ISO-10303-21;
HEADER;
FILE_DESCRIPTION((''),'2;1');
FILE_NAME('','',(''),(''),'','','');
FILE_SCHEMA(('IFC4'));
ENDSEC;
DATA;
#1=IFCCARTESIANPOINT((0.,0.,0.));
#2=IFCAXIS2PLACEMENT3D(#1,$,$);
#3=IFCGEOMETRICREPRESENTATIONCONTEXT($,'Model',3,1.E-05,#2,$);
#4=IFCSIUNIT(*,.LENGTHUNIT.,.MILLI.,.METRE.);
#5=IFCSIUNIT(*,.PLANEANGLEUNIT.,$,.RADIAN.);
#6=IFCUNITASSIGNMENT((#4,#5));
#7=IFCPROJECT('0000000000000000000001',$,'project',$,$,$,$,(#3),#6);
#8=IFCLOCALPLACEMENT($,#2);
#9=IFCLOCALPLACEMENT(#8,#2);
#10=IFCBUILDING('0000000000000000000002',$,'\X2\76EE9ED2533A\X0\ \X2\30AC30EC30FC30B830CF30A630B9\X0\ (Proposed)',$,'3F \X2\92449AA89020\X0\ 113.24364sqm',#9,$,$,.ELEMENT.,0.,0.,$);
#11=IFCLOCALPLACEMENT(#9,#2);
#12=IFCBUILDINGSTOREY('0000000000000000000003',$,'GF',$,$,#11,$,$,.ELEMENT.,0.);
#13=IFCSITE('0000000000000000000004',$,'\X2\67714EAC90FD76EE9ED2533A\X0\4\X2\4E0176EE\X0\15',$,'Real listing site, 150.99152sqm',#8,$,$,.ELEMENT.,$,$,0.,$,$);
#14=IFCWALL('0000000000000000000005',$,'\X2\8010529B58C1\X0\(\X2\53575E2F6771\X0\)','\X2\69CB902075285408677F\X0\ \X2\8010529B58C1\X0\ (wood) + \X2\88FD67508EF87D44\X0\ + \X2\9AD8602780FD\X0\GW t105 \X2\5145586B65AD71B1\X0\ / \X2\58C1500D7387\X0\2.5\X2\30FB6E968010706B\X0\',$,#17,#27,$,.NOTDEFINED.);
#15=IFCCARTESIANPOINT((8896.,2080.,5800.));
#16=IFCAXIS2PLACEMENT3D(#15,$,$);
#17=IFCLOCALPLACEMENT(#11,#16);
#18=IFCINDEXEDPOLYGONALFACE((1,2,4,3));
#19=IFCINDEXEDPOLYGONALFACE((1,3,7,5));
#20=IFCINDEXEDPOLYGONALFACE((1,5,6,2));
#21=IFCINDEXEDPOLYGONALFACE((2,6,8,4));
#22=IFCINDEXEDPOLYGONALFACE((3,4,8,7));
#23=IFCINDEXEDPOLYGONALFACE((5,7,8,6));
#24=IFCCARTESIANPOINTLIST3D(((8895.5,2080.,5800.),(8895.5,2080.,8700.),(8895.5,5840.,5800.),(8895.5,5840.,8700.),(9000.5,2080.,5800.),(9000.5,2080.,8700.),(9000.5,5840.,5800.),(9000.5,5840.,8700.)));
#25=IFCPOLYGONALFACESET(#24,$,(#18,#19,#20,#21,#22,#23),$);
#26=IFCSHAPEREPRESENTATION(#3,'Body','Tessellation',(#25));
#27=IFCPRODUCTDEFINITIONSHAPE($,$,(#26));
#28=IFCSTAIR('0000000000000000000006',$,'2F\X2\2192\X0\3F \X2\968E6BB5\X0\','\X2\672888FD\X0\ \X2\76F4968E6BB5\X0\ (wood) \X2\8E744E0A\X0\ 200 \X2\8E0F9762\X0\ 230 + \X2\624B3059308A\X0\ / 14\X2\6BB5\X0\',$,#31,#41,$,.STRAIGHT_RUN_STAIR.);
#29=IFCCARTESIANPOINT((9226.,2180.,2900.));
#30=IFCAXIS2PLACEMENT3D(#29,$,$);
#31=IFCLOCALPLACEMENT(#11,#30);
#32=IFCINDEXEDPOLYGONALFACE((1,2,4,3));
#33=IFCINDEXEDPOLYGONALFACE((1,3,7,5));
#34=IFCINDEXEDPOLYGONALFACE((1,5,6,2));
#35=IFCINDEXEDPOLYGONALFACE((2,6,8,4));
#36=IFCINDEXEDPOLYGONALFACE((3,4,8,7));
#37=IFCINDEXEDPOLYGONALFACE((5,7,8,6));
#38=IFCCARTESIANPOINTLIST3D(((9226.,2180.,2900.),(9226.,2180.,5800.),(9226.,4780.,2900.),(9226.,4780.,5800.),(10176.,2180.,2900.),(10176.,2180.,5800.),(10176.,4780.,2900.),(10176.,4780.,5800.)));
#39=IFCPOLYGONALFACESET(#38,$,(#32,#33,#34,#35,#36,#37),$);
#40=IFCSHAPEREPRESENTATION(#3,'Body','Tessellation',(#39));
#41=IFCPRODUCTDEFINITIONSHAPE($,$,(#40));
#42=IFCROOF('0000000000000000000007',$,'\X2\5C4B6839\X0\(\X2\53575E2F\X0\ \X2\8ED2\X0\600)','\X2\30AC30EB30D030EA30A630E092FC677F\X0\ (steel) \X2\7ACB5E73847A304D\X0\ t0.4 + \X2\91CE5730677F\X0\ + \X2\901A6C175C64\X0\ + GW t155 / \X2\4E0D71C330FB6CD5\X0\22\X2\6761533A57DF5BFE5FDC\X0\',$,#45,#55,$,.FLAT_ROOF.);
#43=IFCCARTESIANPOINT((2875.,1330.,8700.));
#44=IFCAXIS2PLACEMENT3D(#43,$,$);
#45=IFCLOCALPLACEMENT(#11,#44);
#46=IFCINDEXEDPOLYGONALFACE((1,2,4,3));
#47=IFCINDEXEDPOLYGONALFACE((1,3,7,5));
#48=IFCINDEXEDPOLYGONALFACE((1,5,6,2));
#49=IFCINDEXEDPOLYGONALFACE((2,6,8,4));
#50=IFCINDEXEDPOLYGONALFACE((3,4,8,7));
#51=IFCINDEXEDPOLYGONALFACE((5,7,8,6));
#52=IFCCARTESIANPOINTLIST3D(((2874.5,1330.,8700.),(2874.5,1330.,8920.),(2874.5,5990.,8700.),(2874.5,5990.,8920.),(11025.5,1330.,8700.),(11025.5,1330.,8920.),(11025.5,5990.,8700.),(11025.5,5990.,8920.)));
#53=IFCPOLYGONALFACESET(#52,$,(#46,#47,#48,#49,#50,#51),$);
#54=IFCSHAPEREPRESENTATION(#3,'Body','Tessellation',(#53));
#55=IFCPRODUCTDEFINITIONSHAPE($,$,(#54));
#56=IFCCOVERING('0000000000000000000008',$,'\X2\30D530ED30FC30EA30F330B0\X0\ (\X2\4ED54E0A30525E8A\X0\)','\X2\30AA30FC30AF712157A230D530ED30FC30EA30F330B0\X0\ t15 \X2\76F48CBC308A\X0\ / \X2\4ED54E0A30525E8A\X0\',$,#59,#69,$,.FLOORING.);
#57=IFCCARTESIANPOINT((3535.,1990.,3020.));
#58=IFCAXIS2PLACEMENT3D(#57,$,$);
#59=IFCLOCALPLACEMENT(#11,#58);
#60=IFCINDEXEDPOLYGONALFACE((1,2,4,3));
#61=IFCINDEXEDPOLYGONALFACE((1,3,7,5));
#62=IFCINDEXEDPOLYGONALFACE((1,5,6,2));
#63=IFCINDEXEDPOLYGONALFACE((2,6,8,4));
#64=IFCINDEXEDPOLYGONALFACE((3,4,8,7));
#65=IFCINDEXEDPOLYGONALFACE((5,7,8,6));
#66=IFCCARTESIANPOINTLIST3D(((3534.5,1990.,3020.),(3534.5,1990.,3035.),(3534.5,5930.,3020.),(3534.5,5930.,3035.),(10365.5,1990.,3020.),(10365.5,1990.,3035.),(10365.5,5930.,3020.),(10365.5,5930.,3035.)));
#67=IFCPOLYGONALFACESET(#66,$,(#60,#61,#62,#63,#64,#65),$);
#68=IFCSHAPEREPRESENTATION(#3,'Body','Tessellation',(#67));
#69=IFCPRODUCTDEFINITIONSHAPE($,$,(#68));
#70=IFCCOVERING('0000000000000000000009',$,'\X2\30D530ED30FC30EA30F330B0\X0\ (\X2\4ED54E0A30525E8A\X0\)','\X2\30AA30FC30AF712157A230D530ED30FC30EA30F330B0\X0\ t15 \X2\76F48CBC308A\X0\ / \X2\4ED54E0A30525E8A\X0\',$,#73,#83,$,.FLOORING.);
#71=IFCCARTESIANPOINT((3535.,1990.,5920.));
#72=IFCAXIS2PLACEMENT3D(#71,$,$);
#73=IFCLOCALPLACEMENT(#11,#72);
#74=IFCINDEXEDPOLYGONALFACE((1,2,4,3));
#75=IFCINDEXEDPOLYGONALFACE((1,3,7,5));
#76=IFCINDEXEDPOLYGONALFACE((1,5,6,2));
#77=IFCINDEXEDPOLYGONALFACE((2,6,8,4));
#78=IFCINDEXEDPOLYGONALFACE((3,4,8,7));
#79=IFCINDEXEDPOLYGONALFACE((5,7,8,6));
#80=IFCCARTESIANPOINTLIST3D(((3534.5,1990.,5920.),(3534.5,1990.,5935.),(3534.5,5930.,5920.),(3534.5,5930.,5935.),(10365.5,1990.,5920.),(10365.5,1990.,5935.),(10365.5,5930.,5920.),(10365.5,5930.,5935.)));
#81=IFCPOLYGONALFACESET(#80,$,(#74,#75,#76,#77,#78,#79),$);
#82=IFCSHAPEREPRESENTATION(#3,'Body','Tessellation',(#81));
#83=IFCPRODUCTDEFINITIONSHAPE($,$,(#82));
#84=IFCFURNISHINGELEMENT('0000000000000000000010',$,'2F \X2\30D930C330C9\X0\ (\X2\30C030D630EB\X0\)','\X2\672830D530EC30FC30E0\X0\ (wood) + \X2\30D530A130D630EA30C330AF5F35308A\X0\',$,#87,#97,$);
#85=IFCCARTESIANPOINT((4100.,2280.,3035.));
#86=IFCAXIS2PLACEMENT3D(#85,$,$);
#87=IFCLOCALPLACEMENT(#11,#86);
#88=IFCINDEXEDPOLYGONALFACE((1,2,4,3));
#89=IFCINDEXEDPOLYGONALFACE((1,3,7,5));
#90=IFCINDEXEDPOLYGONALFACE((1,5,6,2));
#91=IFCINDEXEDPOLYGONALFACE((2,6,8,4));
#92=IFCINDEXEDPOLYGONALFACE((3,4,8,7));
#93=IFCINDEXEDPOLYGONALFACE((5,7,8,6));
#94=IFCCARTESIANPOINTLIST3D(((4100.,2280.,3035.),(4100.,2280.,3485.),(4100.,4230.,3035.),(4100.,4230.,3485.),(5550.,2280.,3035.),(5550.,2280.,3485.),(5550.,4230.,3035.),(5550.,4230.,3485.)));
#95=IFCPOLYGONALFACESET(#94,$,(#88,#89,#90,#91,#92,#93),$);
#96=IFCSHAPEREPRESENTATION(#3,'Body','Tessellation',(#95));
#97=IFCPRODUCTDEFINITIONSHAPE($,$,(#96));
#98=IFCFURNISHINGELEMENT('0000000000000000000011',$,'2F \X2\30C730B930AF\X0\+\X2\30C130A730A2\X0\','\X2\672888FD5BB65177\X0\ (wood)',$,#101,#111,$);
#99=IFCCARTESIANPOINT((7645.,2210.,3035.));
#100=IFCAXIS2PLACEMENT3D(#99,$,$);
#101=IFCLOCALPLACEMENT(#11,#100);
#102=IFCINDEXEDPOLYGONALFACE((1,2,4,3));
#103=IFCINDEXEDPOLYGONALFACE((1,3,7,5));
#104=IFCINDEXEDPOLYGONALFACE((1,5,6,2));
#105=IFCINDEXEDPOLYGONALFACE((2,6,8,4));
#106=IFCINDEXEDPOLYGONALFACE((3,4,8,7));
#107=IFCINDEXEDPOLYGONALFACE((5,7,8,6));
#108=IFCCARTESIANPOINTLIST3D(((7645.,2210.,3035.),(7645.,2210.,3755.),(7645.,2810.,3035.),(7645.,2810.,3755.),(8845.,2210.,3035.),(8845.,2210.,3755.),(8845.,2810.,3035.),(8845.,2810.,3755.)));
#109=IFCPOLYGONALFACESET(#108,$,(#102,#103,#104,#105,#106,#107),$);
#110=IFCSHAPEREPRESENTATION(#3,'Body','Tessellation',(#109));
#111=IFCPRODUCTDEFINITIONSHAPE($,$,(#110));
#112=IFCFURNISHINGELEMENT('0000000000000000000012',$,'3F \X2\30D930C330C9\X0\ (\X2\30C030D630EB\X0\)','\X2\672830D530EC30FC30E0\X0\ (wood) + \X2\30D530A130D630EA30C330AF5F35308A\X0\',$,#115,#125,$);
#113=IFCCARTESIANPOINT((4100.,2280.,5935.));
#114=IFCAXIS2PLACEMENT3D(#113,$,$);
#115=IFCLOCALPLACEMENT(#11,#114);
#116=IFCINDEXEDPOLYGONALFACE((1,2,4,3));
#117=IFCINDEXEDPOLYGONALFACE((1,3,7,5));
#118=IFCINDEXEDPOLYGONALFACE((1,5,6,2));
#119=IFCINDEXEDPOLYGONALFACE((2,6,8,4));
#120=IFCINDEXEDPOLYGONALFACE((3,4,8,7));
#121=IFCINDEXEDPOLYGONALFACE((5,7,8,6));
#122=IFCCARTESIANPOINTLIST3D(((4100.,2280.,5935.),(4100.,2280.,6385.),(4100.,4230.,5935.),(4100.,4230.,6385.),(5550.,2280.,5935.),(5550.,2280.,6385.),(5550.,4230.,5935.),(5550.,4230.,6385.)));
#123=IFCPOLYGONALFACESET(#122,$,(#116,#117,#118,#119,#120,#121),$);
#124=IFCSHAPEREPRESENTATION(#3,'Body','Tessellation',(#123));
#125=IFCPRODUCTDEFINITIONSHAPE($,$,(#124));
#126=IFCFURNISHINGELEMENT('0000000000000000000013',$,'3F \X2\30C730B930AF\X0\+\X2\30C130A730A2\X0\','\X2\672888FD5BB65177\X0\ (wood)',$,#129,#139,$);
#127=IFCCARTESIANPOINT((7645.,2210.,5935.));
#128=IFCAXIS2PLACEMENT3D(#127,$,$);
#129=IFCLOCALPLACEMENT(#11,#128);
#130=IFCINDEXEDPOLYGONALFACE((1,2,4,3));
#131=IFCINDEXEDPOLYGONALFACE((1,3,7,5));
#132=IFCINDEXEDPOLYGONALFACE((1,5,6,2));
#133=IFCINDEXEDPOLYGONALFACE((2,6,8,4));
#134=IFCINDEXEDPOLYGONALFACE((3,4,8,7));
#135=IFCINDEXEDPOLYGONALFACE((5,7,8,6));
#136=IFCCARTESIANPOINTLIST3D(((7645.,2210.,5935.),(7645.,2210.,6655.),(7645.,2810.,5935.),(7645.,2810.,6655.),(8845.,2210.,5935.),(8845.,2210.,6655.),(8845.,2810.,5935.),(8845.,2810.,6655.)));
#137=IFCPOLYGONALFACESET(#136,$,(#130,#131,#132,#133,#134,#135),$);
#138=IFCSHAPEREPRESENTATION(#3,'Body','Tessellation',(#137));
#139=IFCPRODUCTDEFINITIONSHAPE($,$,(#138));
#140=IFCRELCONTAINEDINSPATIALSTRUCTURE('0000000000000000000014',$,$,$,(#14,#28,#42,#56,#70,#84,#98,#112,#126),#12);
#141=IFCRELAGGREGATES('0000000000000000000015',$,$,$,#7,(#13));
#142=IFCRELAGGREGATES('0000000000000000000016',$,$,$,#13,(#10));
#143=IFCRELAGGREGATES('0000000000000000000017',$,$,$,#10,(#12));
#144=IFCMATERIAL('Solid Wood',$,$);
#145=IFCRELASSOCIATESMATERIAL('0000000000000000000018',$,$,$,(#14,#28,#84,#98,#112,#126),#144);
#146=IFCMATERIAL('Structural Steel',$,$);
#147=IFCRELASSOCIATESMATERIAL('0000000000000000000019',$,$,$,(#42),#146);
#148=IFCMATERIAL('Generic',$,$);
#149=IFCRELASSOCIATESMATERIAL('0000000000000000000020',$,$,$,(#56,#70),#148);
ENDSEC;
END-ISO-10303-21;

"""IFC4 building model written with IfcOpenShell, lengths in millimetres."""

from ifc_helpers import new_model, si_unit, frame, frame_2d, origin, place, context, project, spatial, rectangle, extrude, material, element, save


model = new_model("IFC4")

# Units and contexts
model_context = context("Model", 3, precision=1e-05, world=origin())
ifc_project = project(units=[si_unit("LENGTHUNIT", "METRE", prefix="MILLI"), si_unit("PLANEANGLEUNIT", "RADIAN")], contexts=[model_context])

# Site, building, storey
site_placement = place(None, origin())
site = spatial("IfcSite", under=ifc_project, at=site_placement, Name="東京都目黒区4丁目15", ObjectType="Real listing site, 150.99152sqm", CompositionType="ELEMENT", RefElevation=0.0)
building_placement = place(site_placement, origin())
building = spatial("IfcBuilding", under=site, at=building_placement, Name="目黒区 ガレージハウス (Proposed)", ObjectType="3F 鉄骨造 113.24364sqm", CompositionType="ELEMENT", ElevationOfRefHeight=0.0, ElevationOfTerrain=0.0)
storey_placement = place(building_placement, origin())
storey = spatial("IfcBuildingStorey", under=building, at=storey_placement, Name="GF", CompositionType="ELEMENT", Elevation=0.0)

# Shared definitions
ifc_material_1 = material(Name="Solid Wood")

# Wall
wall_1_placement = place(storey_placement, frame((8896.0, 2080.0, 5800.0)))
element("IfcWall", 1, at=wall_1_placement, inside=storey, material=ifc_material_1, Name="耐力壁(南帯東)", Description="構造用合板 耐力壁 (wood) + 製材軸組 + 高性能GW t105 充填断熱 / 壁倍率2.5・準耐火", PredefinedType="NOTDEFINED", context=model_context, shape_type="SweptSolid", body=[
    extrude(rectangle(XDim=105.0, YDim=3760.0, at=frame_2d((52.0, 1880.0))), frame((8896.0, 2080.0, 5800.0)), (0.0, 0.0, 1.0), 2900.0),
])

# Stair
stair_placement = place(storey_placement, frame((9226.0, 2180.0, 2900.0)))
element("IfcStair", 2, at=stair_placement, inside=storey, material=ifc_material_1, Name="2F→3F 階段", Description="木製 直階段 (wood) 蹴上 200 踏面 230 + 手すり / 14段", PredefinedType="STRAIGHT_RUN_STAIR", context=model_context, shape_type="SweptSolid", body=[
    extrude(rectangle(XDim=950.0, YDim=2600.0, at=frame_2d((475.0, 1300.0))), frame((9226.0, 2180.0, 2900.0)), (0.0, 0.0, 1.0), 2900.0),
])

# Roof
ifc_material_2 = material(Name="Structural Steel")
for number, where, name in (
    (3, (2875.0, 1330.0, 8700.0), "屋根(南帯 軒600)"),
):
    element("IfcRoof", number, at=place(storey_placement, frame(where)), inside=storey, material=ifc_material_2, Name=name, Description="ガルバリウム鋼板 (steel) 立平葺き t0.4 + 野地板 + 通気層 + GW t155 / 不燃・法22条区域対応", PredefinedType="FLAT_ROOF", context=model_context, shape_type="SweptSolid", body=[
        extrude(rectangle(XDim=8151.0, YDim=4660.0, at=frame_2d((4075.0, 2330.0))), frame((2875.0, 1330.0, 8700.0)), (0.0, 0.0, 1.0), 220.0),
    ])

# Coverings
ifc_material_3 = material(Name="Generic")
covering_1_placement = place(storey_placement, frame((3535.0, 1990.0, 3020.0)))
element("IfcCovering", 4, at=covering_1_placement, inside=storey, material=ifc_material_3, Name="フローリング (仕上げ床)", Description="オーク無垢フローリング t15 直貼り / 仕上げ床", PredefinedType="FLOORING", context=model_context, shape_type="SweptSolid", body=[
    extrude(rectangle(XDim=6831.0, YDim=3940.0, at=frame_2d((3415.0, 1970.0))), frame((3535.0, 1990.0, 3020.0)), (0.0, 0.0, 1.0), 15.0),
])
covering_2_placement = place(storey_placement, frame((3535.0, 1990.0, 5920.0)))
element("IfcCovering", 5, at=covering_2_placement, inside=storey, material=ifc_material_3, Name="フローリング (仕上げ床)", Description="オーク無垢フローリング t15 直貼り / 仕上げ床", PredefinedType="FLOORING", context=model_context, shape_type="SweptSolid", body=[
    extrude(rectangle(XDim=6831.0, YDim=3940.0, at=frame_2d((3415.0, 1970.0))), frame((3535.0, 1990.0, 5920.0)), (0.0, 0.0, 1.0), 15.0),
])

# Furnishing elements
furnishing_1_placement = place(storey_placement, frame((4100.0, 2280.0, 3035.0)))
element("IfcFurnishingElement", 6, at=furnishing_1_placement, inside=storey, material=ifc_material_1, Name="2F ベッド (ダブル)", Description="木フレーム (wood) + ファブリック張り", context=model_context, shape_type="SweptSolid", body=[
    extrude(rectangle(XDim=1450.0, YDim=1950.0, at=frame_2d((725.0, 975.0))), frame((4100.0, 2280.0, 3035.0)), (0.0, 0.0, 1.0), 450.0),
])
furnishing_2_placement = place(storey_placement, frame((7645.0, 2210.0, 3035.0)))
element("IfcFurnishingElement", 7, at=furnishing_2_placement, inside=storey, material=ifc_material_1, Name="2F デスク+チェア", Description="木製家具 (wood)", context=model_context, shape_type="SweptSolid", body=[
    extrude(rectangle(XDim=1200.0, YDim=600.0, at=frame_2d((600.0, 300.0))), frame((7645.0, 2210.0, 3035.0)), (0.0, 0.0, 1.0), 720.0),
])
furnishing_3_placement = place(storey_placement, frame((4100.0, 2280.0, 5935.0)))
element("IfcFurnishingElement", 8, at=furnishing_3_placement, inside=storey, material=ifc_material_1, Name="3F ベッド (ダブル)", Description="木フレーム (wood) + ファブリック張り", context=model_context, shape_type="SweptSolid", body=[
    extrude(rectangle(XDim=1450.0, YDim=1950.0, at=frame_2d((725.0, 975.0))), frame((4100.0, 2280.0, 5935.0)), (0.0, 0.0, 1.0), 450.0),
])
furnishing_4_placement = place(storey_placement, frame((7645.0, 2210.0, 5935.0)))
element("IfcFurnishingElement", 9, at=furnishing_4_placement, inside=storey, material=ifc_material_1, Name="3F デスク+チェア", Description="木製家具 (wood)", context=model_context, shape_type="SweptSolid", body=[
    extrude(rectangle(XDim=1200.0, YDim=600.0, at=frame_2d((600.0, 300.0))), frame((7645.0, 2210.0, 5935.0)), (0.0, 0.0, 1.0), 720.0),
])

save(model, "model.ifc")
